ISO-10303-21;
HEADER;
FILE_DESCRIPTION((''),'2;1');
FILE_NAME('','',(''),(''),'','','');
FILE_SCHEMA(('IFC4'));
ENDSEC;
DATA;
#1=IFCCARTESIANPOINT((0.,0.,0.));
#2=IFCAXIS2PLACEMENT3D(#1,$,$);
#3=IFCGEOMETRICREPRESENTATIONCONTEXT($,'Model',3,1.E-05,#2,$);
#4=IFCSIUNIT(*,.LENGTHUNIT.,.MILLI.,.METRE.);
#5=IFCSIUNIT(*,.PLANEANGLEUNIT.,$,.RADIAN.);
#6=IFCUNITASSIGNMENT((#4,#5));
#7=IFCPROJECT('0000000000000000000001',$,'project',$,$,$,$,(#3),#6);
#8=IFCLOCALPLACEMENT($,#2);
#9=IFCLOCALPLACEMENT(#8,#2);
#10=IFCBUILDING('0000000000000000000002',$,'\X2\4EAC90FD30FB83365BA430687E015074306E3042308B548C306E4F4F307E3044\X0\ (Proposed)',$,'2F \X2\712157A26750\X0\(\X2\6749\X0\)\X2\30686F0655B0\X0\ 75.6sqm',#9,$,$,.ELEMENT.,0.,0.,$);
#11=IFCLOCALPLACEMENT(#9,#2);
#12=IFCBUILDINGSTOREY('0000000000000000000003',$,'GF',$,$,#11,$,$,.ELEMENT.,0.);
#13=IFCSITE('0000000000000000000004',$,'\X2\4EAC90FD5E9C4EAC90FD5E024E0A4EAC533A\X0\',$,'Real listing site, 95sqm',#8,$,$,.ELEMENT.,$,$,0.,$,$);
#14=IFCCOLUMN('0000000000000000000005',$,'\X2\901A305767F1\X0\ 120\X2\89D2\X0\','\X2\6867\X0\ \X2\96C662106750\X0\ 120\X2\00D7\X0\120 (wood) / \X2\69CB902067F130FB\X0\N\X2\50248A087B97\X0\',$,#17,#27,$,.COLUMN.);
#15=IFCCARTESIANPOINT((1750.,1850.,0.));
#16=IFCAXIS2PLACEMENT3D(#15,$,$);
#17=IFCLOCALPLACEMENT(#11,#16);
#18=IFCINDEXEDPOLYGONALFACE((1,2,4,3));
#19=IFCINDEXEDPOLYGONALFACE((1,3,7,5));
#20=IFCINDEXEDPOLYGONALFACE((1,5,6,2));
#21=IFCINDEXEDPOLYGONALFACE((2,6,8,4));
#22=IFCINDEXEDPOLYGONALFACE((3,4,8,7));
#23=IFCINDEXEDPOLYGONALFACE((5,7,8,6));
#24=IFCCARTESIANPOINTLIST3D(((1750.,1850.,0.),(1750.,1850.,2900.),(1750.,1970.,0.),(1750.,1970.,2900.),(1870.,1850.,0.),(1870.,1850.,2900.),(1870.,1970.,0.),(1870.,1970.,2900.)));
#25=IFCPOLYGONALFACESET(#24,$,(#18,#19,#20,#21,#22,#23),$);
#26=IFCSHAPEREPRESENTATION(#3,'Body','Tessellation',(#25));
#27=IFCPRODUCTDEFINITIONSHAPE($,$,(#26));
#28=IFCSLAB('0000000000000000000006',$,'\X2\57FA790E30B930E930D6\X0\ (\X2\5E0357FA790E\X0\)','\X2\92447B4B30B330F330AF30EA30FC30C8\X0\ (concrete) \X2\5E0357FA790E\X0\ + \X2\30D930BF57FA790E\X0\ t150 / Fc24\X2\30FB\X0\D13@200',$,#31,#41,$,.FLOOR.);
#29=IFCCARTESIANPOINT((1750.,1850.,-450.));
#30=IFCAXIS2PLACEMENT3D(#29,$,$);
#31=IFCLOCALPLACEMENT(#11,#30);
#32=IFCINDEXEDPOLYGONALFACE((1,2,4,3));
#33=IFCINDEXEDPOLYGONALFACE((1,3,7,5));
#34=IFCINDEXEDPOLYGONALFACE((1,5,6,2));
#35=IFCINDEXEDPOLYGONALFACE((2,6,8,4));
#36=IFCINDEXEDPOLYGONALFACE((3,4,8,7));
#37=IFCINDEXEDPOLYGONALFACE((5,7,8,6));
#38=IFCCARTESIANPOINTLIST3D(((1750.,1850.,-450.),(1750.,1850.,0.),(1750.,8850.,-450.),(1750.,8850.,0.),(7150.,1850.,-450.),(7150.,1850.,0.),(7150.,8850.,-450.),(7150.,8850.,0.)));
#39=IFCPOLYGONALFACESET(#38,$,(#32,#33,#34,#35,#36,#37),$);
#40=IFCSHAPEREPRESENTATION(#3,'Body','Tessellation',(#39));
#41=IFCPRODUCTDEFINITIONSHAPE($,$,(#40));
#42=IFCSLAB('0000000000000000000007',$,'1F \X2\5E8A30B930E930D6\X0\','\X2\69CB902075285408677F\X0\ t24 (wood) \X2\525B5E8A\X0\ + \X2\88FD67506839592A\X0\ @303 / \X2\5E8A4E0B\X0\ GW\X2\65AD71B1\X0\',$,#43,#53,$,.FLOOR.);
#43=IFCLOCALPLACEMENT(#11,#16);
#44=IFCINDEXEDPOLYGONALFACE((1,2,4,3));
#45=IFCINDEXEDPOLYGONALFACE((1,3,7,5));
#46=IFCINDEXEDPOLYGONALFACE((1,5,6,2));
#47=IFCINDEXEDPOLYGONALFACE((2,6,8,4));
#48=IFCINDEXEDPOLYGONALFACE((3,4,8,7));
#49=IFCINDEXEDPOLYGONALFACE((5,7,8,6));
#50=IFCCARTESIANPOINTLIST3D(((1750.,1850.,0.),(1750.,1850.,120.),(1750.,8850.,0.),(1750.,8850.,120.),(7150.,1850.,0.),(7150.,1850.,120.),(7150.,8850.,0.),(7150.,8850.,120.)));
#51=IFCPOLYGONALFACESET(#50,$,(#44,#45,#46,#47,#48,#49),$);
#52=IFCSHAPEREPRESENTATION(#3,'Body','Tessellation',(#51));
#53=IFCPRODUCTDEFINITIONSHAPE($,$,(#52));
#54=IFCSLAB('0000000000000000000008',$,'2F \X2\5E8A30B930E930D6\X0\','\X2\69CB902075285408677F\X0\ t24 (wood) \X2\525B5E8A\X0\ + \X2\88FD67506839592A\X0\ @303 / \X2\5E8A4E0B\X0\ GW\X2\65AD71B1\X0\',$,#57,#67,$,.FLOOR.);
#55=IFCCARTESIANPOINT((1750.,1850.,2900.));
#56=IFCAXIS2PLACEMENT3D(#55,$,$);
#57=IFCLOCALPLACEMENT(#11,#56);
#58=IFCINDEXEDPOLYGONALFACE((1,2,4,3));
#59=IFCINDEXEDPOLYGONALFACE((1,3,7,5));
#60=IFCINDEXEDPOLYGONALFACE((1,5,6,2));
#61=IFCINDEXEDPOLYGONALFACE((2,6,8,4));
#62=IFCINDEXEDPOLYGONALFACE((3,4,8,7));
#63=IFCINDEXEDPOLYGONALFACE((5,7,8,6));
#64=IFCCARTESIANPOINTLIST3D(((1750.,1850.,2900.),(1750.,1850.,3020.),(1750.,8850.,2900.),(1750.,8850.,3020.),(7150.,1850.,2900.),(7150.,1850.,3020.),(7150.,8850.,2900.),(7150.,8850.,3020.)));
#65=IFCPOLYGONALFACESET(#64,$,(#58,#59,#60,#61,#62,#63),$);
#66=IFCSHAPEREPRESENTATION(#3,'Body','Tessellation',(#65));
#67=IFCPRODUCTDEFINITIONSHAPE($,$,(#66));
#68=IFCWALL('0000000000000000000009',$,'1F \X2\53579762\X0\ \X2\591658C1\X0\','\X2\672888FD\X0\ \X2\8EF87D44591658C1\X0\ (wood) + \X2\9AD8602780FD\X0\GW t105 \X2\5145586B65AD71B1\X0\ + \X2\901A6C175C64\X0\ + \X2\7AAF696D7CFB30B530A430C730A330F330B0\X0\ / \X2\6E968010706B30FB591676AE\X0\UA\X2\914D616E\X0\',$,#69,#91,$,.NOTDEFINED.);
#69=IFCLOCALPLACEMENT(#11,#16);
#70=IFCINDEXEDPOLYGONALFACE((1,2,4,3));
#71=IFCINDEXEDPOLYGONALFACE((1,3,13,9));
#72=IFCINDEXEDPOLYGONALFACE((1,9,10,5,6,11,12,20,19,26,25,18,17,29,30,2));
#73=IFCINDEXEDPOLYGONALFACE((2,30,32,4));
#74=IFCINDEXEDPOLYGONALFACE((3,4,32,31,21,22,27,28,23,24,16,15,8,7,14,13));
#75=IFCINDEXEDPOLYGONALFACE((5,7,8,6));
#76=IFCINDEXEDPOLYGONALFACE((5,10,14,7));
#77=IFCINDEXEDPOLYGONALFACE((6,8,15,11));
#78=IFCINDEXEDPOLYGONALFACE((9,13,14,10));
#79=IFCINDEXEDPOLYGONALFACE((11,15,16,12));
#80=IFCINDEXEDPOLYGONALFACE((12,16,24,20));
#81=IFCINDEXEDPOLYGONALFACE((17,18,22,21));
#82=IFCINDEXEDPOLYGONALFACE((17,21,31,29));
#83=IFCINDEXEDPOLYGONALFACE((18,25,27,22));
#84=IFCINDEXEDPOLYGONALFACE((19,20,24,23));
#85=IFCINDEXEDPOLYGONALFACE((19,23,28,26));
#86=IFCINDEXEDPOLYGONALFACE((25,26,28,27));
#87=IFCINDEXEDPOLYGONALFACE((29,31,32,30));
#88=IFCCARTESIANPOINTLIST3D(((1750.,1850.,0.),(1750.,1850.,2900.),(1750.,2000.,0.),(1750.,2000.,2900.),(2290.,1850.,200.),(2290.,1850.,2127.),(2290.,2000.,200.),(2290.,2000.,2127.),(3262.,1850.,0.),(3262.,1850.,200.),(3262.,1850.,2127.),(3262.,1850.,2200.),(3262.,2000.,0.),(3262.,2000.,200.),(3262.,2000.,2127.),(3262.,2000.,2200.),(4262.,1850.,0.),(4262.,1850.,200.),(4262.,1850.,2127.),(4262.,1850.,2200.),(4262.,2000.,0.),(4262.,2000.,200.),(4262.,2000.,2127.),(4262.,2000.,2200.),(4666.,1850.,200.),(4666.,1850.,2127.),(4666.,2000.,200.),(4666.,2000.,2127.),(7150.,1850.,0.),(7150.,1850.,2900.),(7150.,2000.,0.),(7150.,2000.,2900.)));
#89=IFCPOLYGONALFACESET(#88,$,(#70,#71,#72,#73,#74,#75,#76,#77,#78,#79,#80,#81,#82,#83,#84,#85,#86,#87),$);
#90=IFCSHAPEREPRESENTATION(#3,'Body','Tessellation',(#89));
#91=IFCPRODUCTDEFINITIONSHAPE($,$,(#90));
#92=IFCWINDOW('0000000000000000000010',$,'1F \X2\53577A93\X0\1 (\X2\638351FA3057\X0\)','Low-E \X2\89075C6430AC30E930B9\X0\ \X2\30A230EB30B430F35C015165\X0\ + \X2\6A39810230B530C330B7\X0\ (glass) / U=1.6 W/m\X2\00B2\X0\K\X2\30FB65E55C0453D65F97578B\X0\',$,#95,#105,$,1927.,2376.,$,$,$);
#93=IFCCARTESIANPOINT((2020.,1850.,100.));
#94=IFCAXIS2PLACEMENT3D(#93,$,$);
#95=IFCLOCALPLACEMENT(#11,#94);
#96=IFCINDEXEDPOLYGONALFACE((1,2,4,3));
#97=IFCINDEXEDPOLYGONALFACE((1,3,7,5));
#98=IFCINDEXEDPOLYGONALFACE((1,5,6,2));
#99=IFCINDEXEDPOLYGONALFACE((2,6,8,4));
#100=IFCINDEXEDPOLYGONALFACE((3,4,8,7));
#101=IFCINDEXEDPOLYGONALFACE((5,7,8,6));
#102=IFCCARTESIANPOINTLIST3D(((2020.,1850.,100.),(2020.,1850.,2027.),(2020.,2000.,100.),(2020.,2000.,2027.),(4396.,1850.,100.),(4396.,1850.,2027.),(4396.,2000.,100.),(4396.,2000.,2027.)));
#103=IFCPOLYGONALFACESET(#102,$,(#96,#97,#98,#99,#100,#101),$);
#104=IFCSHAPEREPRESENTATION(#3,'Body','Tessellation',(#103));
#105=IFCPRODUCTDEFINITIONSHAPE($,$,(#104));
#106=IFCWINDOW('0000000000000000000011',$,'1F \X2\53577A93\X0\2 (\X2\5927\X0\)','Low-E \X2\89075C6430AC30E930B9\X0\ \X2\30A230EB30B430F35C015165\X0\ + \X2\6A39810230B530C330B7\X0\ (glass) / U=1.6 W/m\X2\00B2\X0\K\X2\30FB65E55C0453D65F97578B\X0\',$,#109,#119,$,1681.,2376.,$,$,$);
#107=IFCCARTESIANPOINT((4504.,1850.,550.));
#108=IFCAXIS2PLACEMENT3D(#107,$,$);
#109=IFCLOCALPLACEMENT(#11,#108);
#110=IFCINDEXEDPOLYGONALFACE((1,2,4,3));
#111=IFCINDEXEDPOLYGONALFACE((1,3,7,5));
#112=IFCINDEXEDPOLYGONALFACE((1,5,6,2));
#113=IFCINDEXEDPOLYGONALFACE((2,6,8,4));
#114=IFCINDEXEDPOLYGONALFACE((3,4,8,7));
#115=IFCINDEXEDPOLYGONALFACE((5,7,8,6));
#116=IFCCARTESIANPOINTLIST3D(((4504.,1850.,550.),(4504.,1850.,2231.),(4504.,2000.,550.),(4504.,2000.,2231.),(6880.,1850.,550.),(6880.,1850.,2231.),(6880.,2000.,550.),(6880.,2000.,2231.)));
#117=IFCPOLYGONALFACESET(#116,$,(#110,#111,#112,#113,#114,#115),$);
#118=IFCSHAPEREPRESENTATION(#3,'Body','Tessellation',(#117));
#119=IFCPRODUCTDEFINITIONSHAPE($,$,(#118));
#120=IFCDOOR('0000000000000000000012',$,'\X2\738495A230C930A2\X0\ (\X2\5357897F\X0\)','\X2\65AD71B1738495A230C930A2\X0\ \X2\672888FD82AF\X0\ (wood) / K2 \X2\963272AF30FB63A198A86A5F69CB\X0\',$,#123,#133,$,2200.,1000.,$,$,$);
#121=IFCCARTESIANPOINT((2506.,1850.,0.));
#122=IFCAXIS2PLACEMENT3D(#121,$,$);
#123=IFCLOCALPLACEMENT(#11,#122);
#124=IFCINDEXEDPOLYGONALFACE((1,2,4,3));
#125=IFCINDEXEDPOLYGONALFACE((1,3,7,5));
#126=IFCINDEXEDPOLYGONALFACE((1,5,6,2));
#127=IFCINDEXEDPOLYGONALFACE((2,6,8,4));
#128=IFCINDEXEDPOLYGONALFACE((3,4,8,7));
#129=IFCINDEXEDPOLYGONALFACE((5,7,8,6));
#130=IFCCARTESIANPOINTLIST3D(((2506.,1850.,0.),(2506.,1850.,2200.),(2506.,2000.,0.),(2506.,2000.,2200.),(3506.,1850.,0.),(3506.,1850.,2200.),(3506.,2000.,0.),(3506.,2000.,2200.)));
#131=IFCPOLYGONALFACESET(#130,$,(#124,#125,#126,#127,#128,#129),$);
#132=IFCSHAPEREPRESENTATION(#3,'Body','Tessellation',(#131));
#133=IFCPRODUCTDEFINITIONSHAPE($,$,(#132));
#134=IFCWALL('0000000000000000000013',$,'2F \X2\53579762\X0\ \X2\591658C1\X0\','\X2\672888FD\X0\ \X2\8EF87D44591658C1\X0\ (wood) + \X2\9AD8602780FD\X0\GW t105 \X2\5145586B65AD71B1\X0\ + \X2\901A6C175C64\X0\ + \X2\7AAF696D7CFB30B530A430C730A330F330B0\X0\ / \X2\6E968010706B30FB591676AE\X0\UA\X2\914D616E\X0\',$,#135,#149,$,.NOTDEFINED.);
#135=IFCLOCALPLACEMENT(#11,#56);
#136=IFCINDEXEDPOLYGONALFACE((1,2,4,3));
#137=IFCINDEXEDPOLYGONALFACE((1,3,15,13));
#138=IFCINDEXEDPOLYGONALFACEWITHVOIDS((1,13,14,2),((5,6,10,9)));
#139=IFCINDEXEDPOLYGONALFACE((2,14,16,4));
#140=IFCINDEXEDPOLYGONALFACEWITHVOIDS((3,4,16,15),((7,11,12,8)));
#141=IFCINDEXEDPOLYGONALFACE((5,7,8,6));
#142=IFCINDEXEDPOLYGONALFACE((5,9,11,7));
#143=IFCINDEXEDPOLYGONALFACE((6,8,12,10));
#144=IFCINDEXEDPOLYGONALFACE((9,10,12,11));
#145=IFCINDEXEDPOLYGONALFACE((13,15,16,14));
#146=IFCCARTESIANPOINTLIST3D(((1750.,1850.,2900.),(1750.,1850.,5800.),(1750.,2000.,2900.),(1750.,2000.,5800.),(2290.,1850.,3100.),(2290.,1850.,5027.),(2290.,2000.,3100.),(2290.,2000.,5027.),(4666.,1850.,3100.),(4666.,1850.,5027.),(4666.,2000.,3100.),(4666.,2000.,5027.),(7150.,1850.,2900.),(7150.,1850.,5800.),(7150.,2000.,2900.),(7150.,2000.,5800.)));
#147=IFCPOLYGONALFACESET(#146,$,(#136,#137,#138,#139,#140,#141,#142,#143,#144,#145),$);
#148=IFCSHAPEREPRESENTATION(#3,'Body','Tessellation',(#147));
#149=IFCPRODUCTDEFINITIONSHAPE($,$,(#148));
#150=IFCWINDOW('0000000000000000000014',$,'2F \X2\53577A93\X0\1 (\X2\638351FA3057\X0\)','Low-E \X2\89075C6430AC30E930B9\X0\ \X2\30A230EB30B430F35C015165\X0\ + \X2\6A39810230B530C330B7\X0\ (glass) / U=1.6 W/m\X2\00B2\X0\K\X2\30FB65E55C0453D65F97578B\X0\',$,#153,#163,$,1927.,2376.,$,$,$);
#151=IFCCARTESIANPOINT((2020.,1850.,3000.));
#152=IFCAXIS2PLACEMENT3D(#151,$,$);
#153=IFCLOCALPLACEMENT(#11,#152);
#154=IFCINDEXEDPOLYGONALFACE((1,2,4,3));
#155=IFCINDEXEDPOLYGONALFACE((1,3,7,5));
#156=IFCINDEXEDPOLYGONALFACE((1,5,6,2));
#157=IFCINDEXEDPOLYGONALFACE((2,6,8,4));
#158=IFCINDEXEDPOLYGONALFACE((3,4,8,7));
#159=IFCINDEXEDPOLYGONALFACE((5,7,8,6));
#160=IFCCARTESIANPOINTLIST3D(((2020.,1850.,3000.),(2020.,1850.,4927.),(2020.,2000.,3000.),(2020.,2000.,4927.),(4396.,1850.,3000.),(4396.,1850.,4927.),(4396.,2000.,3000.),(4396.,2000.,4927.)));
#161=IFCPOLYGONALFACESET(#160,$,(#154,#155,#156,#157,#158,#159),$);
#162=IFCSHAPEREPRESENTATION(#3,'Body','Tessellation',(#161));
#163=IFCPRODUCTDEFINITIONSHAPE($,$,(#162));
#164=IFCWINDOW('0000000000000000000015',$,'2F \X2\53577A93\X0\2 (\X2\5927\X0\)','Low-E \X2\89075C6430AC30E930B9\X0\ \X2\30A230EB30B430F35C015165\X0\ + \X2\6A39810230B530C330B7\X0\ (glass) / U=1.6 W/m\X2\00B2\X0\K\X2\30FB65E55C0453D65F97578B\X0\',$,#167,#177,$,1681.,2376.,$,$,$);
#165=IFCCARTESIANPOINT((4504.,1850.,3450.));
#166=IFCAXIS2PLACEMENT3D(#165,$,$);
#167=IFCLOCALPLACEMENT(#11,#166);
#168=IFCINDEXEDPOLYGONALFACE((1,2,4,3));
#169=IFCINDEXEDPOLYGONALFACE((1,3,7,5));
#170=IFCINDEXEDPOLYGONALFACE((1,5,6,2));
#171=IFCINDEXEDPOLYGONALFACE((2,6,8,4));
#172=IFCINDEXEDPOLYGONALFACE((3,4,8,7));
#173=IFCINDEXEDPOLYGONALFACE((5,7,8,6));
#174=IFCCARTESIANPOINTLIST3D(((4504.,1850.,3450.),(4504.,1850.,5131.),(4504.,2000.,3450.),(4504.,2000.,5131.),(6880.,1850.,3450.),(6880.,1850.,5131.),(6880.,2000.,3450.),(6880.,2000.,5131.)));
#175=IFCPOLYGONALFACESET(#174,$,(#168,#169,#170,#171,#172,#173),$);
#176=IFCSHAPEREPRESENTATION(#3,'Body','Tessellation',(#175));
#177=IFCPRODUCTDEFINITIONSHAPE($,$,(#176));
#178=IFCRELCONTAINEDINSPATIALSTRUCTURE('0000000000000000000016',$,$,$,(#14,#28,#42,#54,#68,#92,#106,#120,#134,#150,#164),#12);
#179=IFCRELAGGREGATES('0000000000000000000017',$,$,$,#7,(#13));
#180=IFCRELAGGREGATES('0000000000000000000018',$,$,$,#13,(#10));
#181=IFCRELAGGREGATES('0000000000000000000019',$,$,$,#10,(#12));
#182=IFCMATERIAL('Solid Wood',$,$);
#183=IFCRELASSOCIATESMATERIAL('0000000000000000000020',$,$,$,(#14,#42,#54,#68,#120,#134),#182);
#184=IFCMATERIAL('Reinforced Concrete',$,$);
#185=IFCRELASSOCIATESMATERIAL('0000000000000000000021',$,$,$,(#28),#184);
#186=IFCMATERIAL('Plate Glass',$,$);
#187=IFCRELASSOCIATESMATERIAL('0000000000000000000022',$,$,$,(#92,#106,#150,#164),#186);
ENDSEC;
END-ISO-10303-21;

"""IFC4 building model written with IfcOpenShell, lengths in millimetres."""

from ifc_helpers import new_model, si_unit, frame, frame_2d, origin, place, context, project, spatial, rectangle, extrude, material, element, fill, save


model = new_model("IFC4")

# Units and contexts
model_context = context("Model", 3, precision=1e-05, world=origin())
ifc_project = project(units=[si_unit("LENGTHUNIT", "METRE", prefix="MILLI"), si_unit("PLANEANGLEUNIT", "RADIAN")], contexts=[model_context])

# Site, building, storey
site_placement = place(None, origin())
site = spatial("IfcSite", under=ifc_project, at=site_placement, Name="京都府京都市上京区", ObjectType="Real listing site, 95sqm", CompositionType="ELEMENT", RefElevation=0.0)
building_placement = place(site_placement, origin())
building = spatial("IfcBuilding", under=site, at=building_placement, Name="京都・茶室と縁側のある和の住まい (Proposed)", ObjectType="2F 無垢材(杉)と漆喰 75.6sqm", CompositionType="ELEMENT", ElevationOfRefHeight=0.0, ElevationOfTerrain=0.0)
storey_placement = place(building_placement, origin())
storey = spatial("IfcBuildingStorey", under=building, at=storey_placement, Name="GF", CompositionType="ELEMENT", Elevation=0.0)

# Column
ifc_material_1 = material(Name="Solid Wood")
column_placement = place(storey_placement, frame((1750.0, 1850.0, 0.0)))
element("IfcColumn", 1, at=column_placement, inside=storey, material=ifc_material_1, Name="通し柱 120角", Description="桧 集成材 120×120 (wood) / 構造柱・N値計算", PredefinedType="COLUMN", context=model_context, shape_type="SweptSolid", body=[
    extrude(rectangle(XDim=120.0, YDim=120.0, at=frame_2d((60.0, 60.0))), frame((1750.0, 1850.0, 0.0)), (0.0, 0.0, 1.0), 2900.0),
])

# Slabs
ifc_material_2 = material(Name="Reinforced Concrete")
slab_1_placement = place(storey_placement, frame((1750.0, 1850.0, -450.0)))
element("IfcSlab", 2, at=slab_1_placement, inside=storey, material=ifc_material_2, Name="基礎スラブ (布基礎)", Description="鉄筋コンクリート (concrete) 布基礎 + ベタ基礎 t150 / Fc24・D13@200", PredefinedType="FLOOR", context=model_context, shape_type="SweptSolid", body=[
    extrude(rectangle(XDim=5400.0, YDim=7000.0, at=frame_2d((2700.0, 3500.0))), frame((1750.0, 1850.0, -450.0)), (0.0, 0.0, 1.0), 450.0),
])
slab_2_placement = place(storey_placement, frame((1750.0, 1850.0, 0.0)))
element("IfcSlab", 3, at=slab_2_placement, inside=storey, material=ifc_material_1, Name="1F 床スラブ", Description="構造用合板 t24 (wood) 剛床 + 製材根太 @303 / 床下 GW断熱", PredefinedType="FLOOR", context=model_context, shape_type="SweptSolid", body=[
    extrude(rectangle(XDim=5400.0, YDim=7000.0, at=frame_2d((2700.0, 3500.0))), frame((1750.0, 1850.0, 0.0)), (0.0, 0.0, 1.0), 120.0),
])
slab_3_placement = place(storey_placement, frame((1750.0, 1850.0, 2900.0)))
element("IfcSlab", 4, at=slab_3_placement, inside=storey, material=ifc_material_1, Name="2F 床スラブ", Description="構造用合板 t24 (wood) 剛床 + 製材根太 @303 / 床下 GW断熱", PredefinedType="FLOOR", context=model_context, shape_type="SweptSolid", body=[
    extrude(rectangle(XDim=5400.0, YDim=7000.0, at=frame_2d((2700.0, 3500.0))), frame((1750.0, 1850.0, 2900.0)), (0.0, 0.0, 1.0), 120.0),
])

# Wall, openings, windows, door
wall_1_placement = place(storey_placement, frame((1750.0, 1850.0, 0.0)))
wall_1 = element("IfcWall", 5, at=wall_1_placement, inside=storey, material=ifc_material_1, Name="1F 南面 外壁", Description="木製 軸組外壁 (wood) + 高性能GW t105 充填断熱 + 通気層 + 窯業系サイディング / 準耐火・外皮UA配慮", PredefinedType="NOTDEFINED", context=model_context, shape_type="SweptSolid", body=[
    extrude(rectangle(XDim=5400.0, YDim=150.0, at=frame_2d((2700.0, 75.0))), frame((1750.0, 1850.0, 0.0)), (0.0, 0.0, 1.0), 2900.0),
])
opening_1_placement = place(storey_placement, frame((2020.0, 1850.0, 100.0)))
opening_1 = element("IfcOpeningElement", 6, at=opening_1_placement, cuts=wall_1, PredefinedType="NOTDEFINED", context=model_context, shape_type="SweptSolid", body=[
    extrude(rectangle(XDim=2376.0, YDim=150.0, at=frame_2d((1188.0, 75.0))), frame((2020.0, 1850.0, 100.0)), (0.0, 0.0, 1.0), 1927.0),
])
opening_2_placement = place(storey_placement, frame((4504.0, 1850.0, 550.0)))
opening_2 = element("IfcOpeningElement", 7, at=opening_2_placement, cuts=wall_1, PredefinedType="NOTDEFINED", context=model_context, shape_type="SweptSolid", body=[
    extrude(rectangle(XDim=2376.0, YDim=150.0, at=frame_2d((1188.0, 75.0))), frame((4504.0, 1850.0, 550.0)), (0.0, 0.0, 1.0), 1681.0),
])
opening_3_placement = place(storey_placement, frame((2506.0, 1850.0, 0.0)))
opening_3 = element("IfcOpeningElement", 8, at=opening_3_placement, cuts=wall_1, PredefinedType="NOTDEFINED", context=model_context, shape_type="SweptSolid", body=[
    extrude(rectangle(XDim=1000.0, YDim=150.0, at=frame_2d((500.0, 75.0))), frame((2506.0, 1850.0, 0.0)), (0.0, 0.0, 1.0), 2200.0),
])
ifc_material_3 = material(Name="Plate Glass")
window_1_placement = place(storey_placement, frame((2020.0, 1850.0, 100.0)))
window_1 = element("IfcWindow", 9, at=window_1_placement, inside=storey, material=ifc_material_3, Name="1F 南窓1 (掃出し)", Description="Low-E 複層ガラス アルゴン封入 + 樹脂サッシ (glass) / U=1.6 W/m²K・日射取得型", OverallHeight=1927.0, OverallWidth=2376.0, context=model_context, shape_type="SweptSolid", body=[
    extrude(rectangle(XDim=2376.0, YDim=150.0, at=frame_2d((1188.0, 75.0))), frame((2020.0, 1850.0, 100.0)), (0.0, 0.0, 1.0), 1927.0),
])
fill(opening_1, window_1)
window_2_placement = place(storey_placement, frame((4504.0, 1850.0, 550.0)))
window_2 = element("IfcWindow", 10, at=window_2_placement, inside=storey, material=ifc_material_3, Name="1F 南窓2 (大)", Description="Low-E 複層ガラス アルゴン封入 + 樹脂サッシ (glass) / U=1.6 W/m²K・日射取得型", OverallHeight=1681.0, OverallWidth=2376.0, context=model_context, shape_type="SweptSolid", body=[
    extrude(rectangle(XDim=2376.0, YDim=150.0, at=frame_2d((1188.0, 75.0))), frame((4504.0, 1850.0, 550.0)), (0.0, 0.0, 1.0), 1681.0),
])
fill(opening_2, window_2)
door_placement = place(storey_placement, frame((2506.0, 1850.0, 0.0)))
door = element("IfcDoor", 11, at=door_placement, inside=storey, material=ifc_material_1, Name="玄関ドア (南西)", Description="断熱玄関ドア 木製芯 (wood) / K2 防犯・採風機構", OverallHeight=2200.0, OverallWidth=1000.0, context=model_context, shape_type="SweptSolid", body=[
    extrude(rectangle(XDim=1000.0, YDim=150.0, at=frame_2d((500.0, 75.0))), frame((2506.0, 1850.0, 0.0)), (0.0, 0.0, 1.0), 2200.0),
])
fill(opening_3, door)

# Wall, openings, windows
wall_2_placement = place(storey_placement, frame((1750.0, 1850.0, 2900.0)))
wall_2 = element("IfcWall", 12, at=wall_2_placement, inside=storey, material=ifc_material_1, Name="2F 南面 外壁", Description="木製 軸組外壁 (wood) + 高性能GW t105 充填断熱 + 通気層 + 窯業系サイディング / 準耐火・外皮UA配慮", PredefinedType="NOTDEFINED", context=model_context, shape_type="SweptSolid", body=[
    extrude(rectangle(XDim=5400.0, YDim=150.0, at=frame_2d((2700.0, 75.0))), frame((1750.0, 1850.0, 2900.0)), (0.0, 0.0, 1.0), 2900.0),
])
opening_4_placement = place(storey_placement, frame((2020.0, 1850.0, 3000.0)))
opening_4 = element("IfcOpeningElement", 13, at=opening_4_placement, cuts=wall_2, PredefinedType="NOTDEFINED", context=model_context, shape_type="SweptSolid", body=[
    extrude(rectangle(XDim=2376.0, YDim=150.0, at=frame_2d((1188.0, 75.0))), frame((2020.0, 1850.0, 3000.0)), (0.0, 0.0, 1.0), 1927.0),
])
opening_5_placement = place(storey_placement, frame((4504.0, 1850.0, 3450.0)))
opening_5 = element("IfcOpeningElement", 14, at=opening_5_placement, cuts=wall_2, PredefinedType="NOTDEFINED", context=model_context, shape_type="SweptSolid", body=[
    extrude(rectangle(XDim=2376.0, YDim=150.0, at=frame_2d((1188.0, 75.0))), frame((4504.0, 1850.0, 3450.0)), (0.0, 0.0, 1.0), 1681.0),
])
window_3_placement = place(storey_placement, frame((2020.0, 1850.0, 3000.0)))
window_3 = element("IfcWindow", 15, at=window_3_placement, inside=storey, material=ifc_material_3, Name="2F 南窓1 (掃出し)", Description="Low-E 複層ガラス アルゴン封入 + 樹脂サッシ (glass) / U=1.6 W/m²K・日射取得型", OverallHeight=1927.0, OverallWidth=2376.0, context=model_context, shape_type="SweptSolid", body=[
    extrude(rectangle(XDim=2376.0, YDim=150.0, at=frame_2d((1188.0, 75.0))), frame((2020.0, 1850.0, 3000.0)), (0.0, 0.0, 1.0), 1927.0),
])
fill(opening_4, window_3)
window_4_placement = place(storey_placement, frame((4504.0, 1850.0, 3450.0)))
window_4 = element("IfcWindow", 16, at=window_4_placement, inside=storey, material=ifc_material_3, Name="2F 南窓2 (大)", Description="Low-E 複層ガラス アルゴン封入 + 樹脂サッシ (glass) / U=1.6 W/m²K・日射取得型", OverallHeight=1681.0, OverallWidth=2376.0, context=model_context, shape_type="SweptSolid", body=[
    extrude(rectangle(XDim=2376.0, YDim=150.0, at=frame_2d((1188.0, 75.0))), frame((4504.0, 1850.0, 3450.0)), (0.0, 0.0, 1.0), 1681.0),
])
fill(opening_5, window_4)

save(model, "model.ifc")
